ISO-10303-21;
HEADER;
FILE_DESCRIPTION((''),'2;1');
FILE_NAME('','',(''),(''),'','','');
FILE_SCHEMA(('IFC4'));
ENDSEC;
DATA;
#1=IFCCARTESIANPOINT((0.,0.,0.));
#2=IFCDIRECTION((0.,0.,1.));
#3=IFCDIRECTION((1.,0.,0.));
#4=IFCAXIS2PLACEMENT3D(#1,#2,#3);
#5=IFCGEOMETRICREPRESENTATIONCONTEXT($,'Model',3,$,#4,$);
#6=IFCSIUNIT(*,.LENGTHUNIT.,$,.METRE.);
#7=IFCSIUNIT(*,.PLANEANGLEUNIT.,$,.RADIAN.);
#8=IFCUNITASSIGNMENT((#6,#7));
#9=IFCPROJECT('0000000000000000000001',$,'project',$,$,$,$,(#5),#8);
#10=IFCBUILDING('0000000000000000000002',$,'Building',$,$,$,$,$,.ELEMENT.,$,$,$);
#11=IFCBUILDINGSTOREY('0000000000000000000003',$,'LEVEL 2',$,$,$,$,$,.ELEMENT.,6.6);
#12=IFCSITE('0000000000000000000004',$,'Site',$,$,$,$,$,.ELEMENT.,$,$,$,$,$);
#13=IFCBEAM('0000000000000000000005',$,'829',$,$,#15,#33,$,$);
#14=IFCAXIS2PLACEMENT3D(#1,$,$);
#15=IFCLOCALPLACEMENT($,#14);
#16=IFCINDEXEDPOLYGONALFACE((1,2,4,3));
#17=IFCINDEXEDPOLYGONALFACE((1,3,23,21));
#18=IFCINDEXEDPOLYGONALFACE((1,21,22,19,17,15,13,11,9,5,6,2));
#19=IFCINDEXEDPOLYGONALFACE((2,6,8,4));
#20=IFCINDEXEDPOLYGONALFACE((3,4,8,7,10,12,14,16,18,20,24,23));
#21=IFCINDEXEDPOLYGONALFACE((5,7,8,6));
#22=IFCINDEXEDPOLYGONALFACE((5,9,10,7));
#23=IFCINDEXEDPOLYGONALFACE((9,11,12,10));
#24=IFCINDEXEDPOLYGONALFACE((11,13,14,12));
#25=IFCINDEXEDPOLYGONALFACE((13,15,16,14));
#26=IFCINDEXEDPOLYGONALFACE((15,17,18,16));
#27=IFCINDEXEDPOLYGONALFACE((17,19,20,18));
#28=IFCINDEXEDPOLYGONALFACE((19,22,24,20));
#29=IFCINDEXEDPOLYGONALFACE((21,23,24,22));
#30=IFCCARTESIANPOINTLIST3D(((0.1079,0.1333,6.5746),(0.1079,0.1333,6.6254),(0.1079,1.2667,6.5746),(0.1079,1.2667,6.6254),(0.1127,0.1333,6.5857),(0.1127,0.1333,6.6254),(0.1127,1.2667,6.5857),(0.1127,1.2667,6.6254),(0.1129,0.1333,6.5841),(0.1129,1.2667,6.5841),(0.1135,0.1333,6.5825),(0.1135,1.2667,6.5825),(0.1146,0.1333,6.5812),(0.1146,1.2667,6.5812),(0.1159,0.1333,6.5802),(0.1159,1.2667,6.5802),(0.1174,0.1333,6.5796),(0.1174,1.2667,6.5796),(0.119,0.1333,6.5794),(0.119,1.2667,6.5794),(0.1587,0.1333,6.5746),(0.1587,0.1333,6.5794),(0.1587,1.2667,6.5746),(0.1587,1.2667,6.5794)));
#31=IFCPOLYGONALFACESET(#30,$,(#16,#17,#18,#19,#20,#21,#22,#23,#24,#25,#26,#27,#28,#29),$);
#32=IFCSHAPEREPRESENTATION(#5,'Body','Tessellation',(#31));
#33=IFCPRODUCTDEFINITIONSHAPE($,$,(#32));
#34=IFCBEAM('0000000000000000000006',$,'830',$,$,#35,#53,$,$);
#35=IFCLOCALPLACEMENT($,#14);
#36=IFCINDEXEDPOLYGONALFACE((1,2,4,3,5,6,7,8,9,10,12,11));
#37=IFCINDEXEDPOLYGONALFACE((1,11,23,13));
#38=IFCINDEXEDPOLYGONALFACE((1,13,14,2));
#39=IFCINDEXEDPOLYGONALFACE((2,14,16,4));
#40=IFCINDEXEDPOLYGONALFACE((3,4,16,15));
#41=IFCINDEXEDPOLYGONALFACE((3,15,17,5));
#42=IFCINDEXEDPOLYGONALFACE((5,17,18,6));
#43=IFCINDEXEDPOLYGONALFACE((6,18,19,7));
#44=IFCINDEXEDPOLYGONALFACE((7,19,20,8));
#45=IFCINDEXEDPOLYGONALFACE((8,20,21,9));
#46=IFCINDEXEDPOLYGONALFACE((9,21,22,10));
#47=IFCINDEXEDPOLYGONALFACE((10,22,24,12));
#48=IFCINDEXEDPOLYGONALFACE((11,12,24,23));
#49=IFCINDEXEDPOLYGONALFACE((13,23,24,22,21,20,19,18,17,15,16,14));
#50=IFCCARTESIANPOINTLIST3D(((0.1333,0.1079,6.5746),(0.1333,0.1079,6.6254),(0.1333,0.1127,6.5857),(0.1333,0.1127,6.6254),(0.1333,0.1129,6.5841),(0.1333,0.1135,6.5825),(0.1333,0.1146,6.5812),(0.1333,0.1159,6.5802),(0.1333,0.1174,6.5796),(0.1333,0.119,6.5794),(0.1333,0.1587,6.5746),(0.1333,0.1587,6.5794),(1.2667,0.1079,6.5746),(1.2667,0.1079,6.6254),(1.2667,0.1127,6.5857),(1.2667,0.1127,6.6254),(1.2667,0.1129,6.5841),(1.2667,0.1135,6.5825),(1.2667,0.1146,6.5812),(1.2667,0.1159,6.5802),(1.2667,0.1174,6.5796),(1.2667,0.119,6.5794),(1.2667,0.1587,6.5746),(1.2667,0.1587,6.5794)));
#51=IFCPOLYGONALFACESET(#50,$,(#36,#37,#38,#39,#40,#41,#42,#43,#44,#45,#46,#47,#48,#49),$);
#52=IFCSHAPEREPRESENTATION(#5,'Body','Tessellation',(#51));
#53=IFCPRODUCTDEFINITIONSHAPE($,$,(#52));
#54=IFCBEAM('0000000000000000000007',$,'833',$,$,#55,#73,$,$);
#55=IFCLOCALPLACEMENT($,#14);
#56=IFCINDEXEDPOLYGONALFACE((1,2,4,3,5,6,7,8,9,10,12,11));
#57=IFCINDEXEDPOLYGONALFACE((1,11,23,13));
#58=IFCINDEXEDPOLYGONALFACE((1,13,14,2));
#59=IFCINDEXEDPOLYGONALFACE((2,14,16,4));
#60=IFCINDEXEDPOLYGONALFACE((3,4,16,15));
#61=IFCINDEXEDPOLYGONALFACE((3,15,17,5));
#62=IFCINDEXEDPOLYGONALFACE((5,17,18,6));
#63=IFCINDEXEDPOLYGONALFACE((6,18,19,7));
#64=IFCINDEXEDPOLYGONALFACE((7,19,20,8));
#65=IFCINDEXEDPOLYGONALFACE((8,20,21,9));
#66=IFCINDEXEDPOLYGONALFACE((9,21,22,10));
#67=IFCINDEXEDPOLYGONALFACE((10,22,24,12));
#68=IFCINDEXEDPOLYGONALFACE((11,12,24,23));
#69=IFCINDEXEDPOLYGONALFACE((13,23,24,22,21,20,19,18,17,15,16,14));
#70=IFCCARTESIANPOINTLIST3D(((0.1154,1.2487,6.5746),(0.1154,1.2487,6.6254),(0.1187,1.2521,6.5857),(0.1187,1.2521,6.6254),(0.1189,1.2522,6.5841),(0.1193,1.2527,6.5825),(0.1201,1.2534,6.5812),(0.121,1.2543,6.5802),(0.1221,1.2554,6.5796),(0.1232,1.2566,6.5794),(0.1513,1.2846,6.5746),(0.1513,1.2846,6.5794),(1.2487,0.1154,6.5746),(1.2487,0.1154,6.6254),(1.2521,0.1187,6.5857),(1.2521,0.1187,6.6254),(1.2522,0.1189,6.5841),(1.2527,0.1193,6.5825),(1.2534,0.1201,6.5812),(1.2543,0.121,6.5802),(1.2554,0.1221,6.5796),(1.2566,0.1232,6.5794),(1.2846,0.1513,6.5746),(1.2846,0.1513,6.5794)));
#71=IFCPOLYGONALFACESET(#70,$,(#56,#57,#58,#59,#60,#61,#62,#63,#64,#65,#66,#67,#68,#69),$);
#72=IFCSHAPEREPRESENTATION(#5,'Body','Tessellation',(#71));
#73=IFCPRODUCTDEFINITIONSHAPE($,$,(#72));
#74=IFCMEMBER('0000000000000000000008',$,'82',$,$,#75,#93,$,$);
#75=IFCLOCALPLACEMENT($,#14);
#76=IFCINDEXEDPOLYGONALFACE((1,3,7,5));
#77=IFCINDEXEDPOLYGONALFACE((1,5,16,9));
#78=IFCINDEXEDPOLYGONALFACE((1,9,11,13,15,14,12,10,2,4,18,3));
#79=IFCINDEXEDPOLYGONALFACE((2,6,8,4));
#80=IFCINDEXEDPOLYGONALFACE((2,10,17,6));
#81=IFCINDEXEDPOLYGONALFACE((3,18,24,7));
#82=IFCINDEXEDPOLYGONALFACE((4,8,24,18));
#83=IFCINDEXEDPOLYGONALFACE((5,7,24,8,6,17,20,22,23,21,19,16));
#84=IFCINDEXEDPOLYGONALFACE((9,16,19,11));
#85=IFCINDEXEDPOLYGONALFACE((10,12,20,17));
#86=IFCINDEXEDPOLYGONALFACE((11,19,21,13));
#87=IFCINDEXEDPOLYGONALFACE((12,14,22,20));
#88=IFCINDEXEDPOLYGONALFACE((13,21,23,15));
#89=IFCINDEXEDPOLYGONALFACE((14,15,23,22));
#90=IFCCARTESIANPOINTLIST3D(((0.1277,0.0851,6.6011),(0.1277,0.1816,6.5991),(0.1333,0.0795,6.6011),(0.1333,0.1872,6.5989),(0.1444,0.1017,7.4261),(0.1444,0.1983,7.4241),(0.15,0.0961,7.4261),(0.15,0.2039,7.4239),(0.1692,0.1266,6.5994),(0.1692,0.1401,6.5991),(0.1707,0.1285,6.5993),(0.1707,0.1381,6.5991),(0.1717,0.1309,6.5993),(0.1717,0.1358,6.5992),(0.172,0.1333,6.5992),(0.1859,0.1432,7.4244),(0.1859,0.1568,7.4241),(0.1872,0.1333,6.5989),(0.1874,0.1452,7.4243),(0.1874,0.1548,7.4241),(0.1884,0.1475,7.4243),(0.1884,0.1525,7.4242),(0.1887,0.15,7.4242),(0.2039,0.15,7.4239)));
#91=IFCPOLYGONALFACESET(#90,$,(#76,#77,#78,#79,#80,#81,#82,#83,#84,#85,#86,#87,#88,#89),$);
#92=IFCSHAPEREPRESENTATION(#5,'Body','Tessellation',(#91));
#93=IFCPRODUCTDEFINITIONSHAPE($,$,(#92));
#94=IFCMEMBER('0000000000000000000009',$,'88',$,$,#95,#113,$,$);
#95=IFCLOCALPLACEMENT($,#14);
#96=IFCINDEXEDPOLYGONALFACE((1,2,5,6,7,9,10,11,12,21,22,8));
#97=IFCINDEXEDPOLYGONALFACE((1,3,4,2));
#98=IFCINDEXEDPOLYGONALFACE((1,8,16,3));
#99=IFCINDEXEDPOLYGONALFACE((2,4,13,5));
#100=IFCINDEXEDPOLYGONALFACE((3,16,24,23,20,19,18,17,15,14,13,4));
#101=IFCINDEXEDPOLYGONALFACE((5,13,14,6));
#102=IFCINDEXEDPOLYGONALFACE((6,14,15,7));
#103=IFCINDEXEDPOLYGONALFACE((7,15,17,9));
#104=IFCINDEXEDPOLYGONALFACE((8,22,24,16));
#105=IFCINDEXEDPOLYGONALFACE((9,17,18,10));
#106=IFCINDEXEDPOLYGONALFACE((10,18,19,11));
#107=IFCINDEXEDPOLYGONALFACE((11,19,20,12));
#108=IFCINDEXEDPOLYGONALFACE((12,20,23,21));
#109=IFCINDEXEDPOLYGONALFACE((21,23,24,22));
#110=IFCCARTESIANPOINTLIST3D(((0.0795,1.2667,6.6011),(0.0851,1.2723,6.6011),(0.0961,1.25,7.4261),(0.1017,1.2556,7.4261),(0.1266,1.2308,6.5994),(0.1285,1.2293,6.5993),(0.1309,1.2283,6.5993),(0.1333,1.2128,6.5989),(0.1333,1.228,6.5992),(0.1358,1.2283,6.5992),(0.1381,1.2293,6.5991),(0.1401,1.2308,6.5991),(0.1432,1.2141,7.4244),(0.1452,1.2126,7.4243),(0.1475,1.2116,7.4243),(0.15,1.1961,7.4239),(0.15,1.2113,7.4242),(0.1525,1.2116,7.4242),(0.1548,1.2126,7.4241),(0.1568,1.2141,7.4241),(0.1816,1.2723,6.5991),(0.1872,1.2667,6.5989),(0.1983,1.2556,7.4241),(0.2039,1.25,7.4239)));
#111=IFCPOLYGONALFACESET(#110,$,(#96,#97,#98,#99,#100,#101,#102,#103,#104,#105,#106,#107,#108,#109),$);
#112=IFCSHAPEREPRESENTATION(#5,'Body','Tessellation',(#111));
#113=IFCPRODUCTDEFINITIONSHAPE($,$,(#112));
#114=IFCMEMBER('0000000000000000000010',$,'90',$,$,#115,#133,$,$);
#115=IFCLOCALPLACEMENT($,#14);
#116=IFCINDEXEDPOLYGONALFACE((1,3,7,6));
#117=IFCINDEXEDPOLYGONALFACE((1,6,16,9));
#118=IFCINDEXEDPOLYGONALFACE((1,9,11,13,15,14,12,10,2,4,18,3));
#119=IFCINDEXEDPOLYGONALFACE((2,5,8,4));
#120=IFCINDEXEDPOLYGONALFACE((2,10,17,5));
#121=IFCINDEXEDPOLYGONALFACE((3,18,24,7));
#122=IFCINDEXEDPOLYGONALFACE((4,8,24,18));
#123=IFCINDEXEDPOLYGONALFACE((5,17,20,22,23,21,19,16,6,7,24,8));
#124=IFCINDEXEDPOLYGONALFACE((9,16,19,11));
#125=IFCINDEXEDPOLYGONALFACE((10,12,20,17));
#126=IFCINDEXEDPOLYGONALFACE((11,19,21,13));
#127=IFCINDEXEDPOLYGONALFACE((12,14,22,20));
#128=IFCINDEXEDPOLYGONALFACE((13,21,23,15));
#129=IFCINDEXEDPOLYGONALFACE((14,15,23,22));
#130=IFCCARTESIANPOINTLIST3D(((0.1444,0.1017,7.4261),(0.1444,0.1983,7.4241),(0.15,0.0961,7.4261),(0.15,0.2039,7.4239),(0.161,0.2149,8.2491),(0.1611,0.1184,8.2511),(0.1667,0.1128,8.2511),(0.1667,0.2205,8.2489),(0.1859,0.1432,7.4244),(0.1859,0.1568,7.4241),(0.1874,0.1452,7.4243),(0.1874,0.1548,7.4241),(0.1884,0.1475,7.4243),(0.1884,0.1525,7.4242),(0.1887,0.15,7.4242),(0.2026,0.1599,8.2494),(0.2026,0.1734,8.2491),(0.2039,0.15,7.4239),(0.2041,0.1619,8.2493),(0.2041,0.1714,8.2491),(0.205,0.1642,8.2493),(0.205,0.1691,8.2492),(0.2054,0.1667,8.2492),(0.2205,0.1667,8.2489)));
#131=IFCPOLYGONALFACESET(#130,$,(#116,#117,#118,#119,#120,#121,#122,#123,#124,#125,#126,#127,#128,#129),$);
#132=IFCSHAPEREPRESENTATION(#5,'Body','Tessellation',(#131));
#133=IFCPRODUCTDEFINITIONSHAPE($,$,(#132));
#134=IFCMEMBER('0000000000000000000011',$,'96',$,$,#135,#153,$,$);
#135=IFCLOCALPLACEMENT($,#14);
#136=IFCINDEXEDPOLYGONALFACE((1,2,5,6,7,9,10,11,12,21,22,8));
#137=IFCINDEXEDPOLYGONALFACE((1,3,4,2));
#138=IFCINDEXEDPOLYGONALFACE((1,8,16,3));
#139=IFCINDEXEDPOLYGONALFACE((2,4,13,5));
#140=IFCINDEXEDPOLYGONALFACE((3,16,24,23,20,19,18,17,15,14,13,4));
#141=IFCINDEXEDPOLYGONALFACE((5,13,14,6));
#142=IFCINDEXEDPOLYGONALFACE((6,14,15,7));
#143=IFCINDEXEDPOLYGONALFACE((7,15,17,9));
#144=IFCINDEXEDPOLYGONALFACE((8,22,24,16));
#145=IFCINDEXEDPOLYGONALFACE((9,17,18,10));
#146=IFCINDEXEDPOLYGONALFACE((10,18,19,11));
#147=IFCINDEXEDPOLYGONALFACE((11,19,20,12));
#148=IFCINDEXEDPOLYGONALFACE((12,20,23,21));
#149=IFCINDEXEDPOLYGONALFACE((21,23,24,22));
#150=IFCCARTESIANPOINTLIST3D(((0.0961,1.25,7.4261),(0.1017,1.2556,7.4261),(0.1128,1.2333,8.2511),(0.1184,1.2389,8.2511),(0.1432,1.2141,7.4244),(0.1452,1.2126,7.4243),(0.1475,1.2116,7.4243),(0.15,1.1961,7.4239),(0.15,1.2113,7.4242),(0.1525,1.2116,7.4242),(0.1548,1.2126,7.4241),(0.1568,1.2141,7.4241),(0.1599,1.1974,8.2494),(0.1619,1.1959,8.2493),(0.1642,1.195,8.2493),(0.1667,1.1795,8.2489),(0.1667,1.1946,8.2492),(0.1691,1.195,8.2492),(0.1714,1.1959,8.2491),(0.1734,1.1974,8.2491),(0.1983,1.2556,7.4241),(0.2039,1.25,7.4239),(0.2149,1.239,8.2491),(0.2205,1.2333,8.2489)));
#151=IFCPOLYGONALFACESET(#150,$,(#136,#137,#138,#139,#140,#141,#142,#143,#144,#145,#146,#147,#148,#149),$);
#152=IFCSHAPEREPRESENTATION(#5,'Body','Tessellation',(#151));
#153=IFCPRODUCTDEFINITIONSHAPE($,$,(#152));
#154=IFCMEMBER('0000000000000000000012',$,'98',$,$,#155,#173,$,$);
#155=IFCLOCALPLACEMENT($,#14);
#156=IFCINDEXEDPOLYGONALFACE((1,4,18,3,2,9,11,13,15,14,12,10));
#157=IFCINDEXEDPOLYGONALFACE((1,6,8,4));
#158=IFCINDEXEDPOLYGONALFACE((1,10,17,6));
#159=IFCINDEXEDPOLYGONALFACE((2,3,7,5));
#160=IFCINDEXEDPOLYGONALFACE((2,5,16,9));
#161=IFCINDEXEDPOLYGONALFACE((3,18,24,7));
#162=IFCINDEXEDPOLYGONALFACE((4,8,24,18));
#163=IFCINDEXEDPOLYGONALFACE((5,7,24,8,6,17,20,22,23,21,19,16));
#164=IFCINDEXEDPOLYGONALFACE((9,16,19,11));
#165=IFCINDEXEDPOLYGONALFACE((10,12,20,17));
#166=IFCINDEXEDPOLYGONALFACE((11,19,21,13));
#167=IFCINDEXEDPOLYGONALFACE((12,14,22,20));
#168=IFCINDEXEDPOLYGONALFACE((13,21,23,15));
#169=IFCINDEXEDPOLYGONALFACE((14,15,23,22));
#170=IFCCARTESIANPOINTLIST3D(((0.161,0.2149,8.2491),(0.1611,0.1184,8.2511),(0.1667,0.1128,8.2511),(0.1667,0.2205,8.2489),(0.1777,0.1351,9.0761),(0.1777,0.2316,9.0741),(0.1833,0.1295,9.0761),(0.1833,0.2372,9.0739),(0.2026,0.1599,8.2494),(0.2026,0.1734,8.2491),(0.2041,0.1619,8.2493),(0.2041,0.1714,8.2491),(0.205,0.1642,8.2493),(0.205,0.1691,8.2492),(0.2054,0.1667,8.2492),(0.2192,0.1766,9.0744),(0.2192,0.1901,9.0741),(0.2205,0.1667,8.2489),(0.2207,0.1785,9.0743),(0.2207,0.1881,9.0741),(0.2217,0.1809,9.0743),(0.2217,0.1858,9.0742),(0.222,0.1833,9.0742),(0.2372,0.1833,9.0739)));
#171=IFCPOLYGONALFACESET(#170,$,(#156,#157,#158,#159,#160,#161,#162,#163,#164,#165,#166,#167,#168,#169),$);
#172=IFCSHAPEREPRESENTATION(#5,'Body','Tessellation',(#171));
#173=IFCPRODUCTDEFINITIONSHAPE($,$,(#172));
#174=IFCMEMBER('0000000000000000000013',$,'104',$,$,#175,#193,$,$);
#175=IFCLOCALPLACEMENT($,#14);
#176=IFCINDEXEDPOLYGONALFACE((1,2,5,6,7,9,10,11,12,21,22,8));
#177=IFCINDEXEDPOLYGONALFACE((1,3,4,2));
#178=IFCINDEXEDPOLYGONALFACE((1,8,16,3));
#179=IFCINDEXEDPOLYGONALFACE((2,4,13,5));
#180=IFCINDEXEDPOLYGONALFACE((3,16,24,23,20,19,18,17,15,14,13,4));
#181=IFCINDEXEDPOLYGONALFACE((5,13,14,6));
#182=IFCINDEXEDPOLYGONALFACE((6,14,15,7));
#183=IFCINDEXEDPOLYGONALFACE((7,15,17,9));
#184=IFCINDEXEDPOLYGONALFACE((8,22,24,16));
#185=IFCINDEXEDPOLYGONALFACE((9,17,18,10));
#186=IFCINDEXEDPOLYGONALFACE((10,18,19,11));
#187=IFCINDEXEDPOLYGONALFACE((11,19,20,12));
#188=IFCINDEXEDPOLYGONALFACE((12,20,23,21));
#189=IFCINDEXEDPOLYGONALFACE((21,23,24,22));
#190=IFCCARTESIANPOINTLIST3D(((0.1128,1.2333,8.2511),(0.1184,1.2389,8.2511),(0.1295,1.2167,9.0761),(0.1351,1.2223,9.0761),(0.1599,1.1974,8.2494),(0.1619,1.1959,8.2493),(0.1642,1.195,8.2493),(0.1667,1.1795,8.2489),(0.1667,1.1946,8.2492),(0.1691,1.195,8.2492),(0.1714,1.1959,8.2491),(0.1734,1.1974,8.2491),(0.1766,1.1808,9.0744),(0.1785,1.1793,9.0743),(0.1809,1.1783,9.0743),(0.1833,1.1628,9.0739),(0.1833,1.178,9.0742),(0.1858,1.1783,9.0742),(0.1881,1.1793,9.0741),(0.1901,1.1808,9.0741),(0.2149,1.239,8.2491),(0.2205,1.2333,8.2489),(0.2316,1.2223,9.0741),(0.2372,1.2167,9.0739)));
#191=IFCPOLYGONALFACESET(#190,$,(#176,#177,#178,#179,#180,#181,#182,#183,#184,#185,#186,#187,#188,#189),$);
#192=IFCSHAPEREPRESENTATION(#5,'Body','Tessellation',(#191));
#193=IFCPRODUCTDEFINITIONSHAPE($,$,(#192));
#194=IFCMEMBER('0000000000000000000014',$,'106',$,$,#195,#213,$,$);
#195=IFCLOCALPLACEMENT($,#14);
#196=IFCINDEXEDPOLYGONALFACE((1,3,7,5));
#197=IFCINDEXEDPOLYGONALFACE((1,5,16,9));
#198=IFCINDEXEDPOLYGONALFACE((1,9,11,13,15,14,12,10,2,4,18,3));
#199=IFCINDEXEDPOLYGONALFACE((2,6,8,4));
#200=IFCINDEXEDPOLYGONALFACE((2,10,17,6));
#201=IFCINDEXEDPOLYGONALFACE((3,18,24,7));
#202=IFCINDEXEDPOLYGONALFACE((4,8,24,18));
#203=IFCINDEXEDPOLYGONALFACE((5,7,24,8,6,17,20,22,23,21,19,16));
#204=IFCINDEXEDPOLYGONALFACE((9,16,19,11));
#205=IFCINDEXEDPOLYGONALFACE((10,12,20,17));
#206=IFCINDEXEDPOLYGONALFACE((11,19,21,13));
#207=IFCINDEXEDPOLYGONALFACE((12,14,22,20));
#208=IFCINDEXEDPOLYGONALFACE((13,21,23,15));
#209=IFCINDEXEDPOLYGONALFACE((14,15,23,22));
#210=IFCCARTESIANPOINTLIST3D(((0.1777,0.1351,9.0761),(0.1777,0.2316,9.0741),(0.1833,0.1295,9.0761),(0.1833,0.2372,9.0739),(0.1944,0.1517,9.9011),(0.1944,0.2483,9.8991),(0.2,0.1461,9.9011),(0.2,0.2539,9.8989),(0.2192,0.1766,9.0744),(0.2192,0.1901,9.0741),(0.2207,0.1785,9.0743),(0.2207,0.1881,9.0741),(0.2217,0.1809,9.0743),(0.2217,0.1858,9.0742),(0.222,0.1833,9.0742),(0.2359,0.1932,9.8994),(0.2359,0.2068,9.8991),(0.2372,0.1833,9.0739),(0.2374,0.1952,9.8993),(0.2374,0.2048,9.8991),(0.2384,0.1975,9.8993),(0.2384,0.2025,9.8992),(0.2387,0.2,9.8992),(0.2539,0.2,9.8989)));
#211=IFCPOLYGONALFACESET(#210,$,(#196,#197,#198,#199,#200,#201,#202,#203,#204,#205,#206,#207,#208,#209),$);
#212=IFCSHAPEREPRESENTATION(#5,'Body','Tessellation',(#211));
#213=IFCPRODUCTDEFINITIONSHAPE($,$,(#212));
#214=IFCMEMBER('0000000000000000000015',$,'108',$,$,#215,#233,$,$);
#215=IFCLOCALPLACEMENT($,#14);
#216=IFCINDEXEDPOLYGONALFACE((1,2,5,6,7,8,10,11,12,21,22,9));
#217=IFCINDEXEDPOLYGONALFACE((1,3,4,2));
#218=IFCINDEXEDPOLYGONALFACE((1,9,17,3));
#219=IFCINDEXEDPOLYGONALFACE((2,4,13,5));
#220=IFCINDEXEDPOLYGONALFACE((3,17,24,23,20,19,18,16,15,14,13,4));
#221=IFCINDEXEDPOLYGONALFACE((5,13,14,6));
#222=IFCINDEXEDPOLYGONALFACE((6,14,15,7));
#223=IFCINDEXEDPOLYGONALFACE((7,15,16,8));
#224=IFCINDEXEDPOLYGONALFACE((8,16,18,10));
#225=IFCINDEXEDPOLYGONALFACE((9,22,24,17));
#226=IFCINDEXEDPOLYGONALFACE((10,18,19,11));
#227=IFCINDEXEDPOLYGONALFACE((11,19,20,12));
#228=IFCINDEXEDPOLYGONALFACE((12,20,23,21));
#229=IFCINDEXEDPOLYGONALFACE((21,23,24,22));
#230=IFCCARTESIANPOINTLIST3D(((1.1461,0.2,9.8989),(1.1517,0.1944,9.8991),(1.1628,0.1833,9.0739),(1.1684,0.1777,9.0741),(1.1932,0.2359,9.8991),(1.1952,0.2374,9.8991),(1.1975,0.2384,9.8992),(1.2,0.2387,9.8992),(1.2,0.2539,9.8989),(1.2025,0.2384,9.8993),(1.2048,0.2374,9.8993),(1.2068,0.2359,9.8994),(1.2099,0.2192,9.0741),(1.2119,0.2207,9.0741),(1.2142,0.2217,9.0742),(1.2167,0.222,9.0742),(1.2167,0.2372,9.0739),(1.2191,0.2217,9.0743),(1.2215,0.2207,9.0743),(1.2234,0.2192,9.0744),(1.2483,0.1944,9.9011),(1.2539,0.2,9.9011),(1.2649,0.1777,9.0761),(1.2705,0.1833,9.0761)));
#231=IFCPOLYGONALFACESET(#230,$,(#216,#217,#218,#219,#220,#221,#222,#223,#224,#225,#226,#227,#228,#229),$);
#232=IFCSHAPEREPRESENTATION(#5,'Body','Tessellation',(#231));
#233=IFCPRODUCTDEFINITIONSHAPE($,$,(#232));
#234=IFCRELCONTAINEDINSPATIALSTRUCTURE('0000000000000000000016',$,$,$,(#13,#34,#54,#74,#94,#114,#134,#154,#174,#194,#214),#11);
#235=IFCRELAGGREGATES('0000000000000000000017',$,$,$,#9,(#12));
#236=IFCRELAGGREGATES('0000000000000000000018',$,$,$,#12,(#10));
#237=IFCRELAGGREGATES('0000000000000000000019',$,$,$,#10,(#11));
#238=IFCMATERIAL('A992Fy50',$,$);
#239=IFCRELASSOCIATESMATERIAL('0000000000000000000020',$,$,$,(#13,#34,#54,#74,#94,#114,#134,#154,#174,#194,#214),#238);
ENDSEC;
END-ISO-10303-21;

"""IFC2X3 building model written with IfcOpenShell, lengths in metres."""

from ifc_helpers import new_model, si_unit, frame, origin_with_axes, origin_2d_with_axis, place, context, project, spatial, l_section, extrude, material, element, save


model = new_model("IFC2X3")

# Units and contexts
model_context = context("Model", 3, world=origin_with_axes())
ifc_project = project(units=[si_unit("LENGTHUNIT", "METRE"), si_unit("PLANEANGLEUNIT", "RADIAN")], contexts=[model_context])

# Site, building, storey
site = spatial("IfcSite", under=ifc_project, Name="Site", CompositionType="ELEMENT")
building = spatial("IfcBuilding", under=site, Name="Building", CompositionType="ELEMENT")
storey = spatial("IfcBuildingStorey", under=building, Name="LEVEL 2", CompositionType="ELEMENT", Elevation=6.6)

# Beams
ifc_material = material(Name="A992Fy50")
for number, where, z_axis, x_axis, name in (
    (1, (0.1333, 1.2667, 6.6), (0.0, -1.0, 0.0), (1.0, 0.0, 0.0), "829"),
    (2, (0.1333, 0.1333, 6.6), (1.0, 0.0, 0.0), (0.0, 1.0, 0.0), "830"),
):
    element("IfcBeam", number, at=place(None, frame(where, z_axis=z_axis, x_axis=x_axis)), inside=storey, material=ifc_material, Name=name, context=model_context, shape_type="SweptSolid", body=[
        extrude(l_section(Depth=0.0508, Width=0.0508, Thickness=0.0048, FilletRadius=0.0063, at=origin_2d_with_axis()), origin_with_axes(), (0.0, 0.0, 1.0), 1.1333),
    ])
beam_placement = place(None, frame((0.1333, 1.2667, 6.6), z_axis=(0.707107, -0.707107, 0.0), x_axis=(0.707107, 0.707107, 0.0)))
element("IfcBeam", 3, at=beam_placement, inside=storey, material=ifc_material, Name="833", context=model_context, shape_type="SweptSolid", body=[
    extrude(l_section(Depth=0.0508, Width=0.0508, Thickness=0.0048, FilletRadius=0.0063, at=origin_2d_with_axis()), origin_with_axes(), (0.0, 0.0, 1.0), 1.6028),
])

# Members
for number, where, z_axis, x_axis, name in (
    (4, (0.1333, 0.1333, 6.6), (0.020194, 0.020194, 0.999592), (-0.707107, 0.707107, 0.0), "82"),
    (5, (0.1333, 1.2667, 6.6), (0.020194, -0.020194, 0.999592), (0.707107, 0.707107, 0.0), "88"),
    (6, (0.15, 0.15, 7.425), (0.020194, 0.020194, 0.999592), (-0.707107, 0.707107, 0.0), "90"),
    (7, (0.15, 1.25, 7.425), (0.020194, -0.020194, 0.999592), (0.707107, 0.707107, 0.0), "96"),
    (8, (0.1667, 0.1667, 8.25), (0.020194, 0.020194, 0.999592), (-0.707107, 0.707107, 0.0), "98"),
    (9, (0.1667, 1.2333, 8.25), (0.020194, -0.020194, 0.999592), (0.707107, 0.707107, 0.0), "104"),
    (10, (0.1833, 0.1833, 9.075), (0.020194, 0.020194, 0.999592), (-0.707107, 0.707107, 0.0), "106"),
    (11, (1.2167, 0.1833, 9.075), (-0.020194, 0.020194, 0.999592), (-0.707107, -0.707107, 0.0), "108"),
):
    element("IfcMember", number, at=place(None, frame(where, z_axis=z_axis, x_axis=x_axis)), inside=storey, material=ifc_material, Name=name, context=model_context, shape_type="SweptSolid", body=[
        extrude(l_section(Depth=0.0762, Width=0.0762, Thickness=0.0079, FilletRadius=0.0096, at=origin_2d_with_axis()), origin_with_axes(), (0.0, 0.0, 1.0), 0.8253),
    ])

save(model, "model.ifc")
